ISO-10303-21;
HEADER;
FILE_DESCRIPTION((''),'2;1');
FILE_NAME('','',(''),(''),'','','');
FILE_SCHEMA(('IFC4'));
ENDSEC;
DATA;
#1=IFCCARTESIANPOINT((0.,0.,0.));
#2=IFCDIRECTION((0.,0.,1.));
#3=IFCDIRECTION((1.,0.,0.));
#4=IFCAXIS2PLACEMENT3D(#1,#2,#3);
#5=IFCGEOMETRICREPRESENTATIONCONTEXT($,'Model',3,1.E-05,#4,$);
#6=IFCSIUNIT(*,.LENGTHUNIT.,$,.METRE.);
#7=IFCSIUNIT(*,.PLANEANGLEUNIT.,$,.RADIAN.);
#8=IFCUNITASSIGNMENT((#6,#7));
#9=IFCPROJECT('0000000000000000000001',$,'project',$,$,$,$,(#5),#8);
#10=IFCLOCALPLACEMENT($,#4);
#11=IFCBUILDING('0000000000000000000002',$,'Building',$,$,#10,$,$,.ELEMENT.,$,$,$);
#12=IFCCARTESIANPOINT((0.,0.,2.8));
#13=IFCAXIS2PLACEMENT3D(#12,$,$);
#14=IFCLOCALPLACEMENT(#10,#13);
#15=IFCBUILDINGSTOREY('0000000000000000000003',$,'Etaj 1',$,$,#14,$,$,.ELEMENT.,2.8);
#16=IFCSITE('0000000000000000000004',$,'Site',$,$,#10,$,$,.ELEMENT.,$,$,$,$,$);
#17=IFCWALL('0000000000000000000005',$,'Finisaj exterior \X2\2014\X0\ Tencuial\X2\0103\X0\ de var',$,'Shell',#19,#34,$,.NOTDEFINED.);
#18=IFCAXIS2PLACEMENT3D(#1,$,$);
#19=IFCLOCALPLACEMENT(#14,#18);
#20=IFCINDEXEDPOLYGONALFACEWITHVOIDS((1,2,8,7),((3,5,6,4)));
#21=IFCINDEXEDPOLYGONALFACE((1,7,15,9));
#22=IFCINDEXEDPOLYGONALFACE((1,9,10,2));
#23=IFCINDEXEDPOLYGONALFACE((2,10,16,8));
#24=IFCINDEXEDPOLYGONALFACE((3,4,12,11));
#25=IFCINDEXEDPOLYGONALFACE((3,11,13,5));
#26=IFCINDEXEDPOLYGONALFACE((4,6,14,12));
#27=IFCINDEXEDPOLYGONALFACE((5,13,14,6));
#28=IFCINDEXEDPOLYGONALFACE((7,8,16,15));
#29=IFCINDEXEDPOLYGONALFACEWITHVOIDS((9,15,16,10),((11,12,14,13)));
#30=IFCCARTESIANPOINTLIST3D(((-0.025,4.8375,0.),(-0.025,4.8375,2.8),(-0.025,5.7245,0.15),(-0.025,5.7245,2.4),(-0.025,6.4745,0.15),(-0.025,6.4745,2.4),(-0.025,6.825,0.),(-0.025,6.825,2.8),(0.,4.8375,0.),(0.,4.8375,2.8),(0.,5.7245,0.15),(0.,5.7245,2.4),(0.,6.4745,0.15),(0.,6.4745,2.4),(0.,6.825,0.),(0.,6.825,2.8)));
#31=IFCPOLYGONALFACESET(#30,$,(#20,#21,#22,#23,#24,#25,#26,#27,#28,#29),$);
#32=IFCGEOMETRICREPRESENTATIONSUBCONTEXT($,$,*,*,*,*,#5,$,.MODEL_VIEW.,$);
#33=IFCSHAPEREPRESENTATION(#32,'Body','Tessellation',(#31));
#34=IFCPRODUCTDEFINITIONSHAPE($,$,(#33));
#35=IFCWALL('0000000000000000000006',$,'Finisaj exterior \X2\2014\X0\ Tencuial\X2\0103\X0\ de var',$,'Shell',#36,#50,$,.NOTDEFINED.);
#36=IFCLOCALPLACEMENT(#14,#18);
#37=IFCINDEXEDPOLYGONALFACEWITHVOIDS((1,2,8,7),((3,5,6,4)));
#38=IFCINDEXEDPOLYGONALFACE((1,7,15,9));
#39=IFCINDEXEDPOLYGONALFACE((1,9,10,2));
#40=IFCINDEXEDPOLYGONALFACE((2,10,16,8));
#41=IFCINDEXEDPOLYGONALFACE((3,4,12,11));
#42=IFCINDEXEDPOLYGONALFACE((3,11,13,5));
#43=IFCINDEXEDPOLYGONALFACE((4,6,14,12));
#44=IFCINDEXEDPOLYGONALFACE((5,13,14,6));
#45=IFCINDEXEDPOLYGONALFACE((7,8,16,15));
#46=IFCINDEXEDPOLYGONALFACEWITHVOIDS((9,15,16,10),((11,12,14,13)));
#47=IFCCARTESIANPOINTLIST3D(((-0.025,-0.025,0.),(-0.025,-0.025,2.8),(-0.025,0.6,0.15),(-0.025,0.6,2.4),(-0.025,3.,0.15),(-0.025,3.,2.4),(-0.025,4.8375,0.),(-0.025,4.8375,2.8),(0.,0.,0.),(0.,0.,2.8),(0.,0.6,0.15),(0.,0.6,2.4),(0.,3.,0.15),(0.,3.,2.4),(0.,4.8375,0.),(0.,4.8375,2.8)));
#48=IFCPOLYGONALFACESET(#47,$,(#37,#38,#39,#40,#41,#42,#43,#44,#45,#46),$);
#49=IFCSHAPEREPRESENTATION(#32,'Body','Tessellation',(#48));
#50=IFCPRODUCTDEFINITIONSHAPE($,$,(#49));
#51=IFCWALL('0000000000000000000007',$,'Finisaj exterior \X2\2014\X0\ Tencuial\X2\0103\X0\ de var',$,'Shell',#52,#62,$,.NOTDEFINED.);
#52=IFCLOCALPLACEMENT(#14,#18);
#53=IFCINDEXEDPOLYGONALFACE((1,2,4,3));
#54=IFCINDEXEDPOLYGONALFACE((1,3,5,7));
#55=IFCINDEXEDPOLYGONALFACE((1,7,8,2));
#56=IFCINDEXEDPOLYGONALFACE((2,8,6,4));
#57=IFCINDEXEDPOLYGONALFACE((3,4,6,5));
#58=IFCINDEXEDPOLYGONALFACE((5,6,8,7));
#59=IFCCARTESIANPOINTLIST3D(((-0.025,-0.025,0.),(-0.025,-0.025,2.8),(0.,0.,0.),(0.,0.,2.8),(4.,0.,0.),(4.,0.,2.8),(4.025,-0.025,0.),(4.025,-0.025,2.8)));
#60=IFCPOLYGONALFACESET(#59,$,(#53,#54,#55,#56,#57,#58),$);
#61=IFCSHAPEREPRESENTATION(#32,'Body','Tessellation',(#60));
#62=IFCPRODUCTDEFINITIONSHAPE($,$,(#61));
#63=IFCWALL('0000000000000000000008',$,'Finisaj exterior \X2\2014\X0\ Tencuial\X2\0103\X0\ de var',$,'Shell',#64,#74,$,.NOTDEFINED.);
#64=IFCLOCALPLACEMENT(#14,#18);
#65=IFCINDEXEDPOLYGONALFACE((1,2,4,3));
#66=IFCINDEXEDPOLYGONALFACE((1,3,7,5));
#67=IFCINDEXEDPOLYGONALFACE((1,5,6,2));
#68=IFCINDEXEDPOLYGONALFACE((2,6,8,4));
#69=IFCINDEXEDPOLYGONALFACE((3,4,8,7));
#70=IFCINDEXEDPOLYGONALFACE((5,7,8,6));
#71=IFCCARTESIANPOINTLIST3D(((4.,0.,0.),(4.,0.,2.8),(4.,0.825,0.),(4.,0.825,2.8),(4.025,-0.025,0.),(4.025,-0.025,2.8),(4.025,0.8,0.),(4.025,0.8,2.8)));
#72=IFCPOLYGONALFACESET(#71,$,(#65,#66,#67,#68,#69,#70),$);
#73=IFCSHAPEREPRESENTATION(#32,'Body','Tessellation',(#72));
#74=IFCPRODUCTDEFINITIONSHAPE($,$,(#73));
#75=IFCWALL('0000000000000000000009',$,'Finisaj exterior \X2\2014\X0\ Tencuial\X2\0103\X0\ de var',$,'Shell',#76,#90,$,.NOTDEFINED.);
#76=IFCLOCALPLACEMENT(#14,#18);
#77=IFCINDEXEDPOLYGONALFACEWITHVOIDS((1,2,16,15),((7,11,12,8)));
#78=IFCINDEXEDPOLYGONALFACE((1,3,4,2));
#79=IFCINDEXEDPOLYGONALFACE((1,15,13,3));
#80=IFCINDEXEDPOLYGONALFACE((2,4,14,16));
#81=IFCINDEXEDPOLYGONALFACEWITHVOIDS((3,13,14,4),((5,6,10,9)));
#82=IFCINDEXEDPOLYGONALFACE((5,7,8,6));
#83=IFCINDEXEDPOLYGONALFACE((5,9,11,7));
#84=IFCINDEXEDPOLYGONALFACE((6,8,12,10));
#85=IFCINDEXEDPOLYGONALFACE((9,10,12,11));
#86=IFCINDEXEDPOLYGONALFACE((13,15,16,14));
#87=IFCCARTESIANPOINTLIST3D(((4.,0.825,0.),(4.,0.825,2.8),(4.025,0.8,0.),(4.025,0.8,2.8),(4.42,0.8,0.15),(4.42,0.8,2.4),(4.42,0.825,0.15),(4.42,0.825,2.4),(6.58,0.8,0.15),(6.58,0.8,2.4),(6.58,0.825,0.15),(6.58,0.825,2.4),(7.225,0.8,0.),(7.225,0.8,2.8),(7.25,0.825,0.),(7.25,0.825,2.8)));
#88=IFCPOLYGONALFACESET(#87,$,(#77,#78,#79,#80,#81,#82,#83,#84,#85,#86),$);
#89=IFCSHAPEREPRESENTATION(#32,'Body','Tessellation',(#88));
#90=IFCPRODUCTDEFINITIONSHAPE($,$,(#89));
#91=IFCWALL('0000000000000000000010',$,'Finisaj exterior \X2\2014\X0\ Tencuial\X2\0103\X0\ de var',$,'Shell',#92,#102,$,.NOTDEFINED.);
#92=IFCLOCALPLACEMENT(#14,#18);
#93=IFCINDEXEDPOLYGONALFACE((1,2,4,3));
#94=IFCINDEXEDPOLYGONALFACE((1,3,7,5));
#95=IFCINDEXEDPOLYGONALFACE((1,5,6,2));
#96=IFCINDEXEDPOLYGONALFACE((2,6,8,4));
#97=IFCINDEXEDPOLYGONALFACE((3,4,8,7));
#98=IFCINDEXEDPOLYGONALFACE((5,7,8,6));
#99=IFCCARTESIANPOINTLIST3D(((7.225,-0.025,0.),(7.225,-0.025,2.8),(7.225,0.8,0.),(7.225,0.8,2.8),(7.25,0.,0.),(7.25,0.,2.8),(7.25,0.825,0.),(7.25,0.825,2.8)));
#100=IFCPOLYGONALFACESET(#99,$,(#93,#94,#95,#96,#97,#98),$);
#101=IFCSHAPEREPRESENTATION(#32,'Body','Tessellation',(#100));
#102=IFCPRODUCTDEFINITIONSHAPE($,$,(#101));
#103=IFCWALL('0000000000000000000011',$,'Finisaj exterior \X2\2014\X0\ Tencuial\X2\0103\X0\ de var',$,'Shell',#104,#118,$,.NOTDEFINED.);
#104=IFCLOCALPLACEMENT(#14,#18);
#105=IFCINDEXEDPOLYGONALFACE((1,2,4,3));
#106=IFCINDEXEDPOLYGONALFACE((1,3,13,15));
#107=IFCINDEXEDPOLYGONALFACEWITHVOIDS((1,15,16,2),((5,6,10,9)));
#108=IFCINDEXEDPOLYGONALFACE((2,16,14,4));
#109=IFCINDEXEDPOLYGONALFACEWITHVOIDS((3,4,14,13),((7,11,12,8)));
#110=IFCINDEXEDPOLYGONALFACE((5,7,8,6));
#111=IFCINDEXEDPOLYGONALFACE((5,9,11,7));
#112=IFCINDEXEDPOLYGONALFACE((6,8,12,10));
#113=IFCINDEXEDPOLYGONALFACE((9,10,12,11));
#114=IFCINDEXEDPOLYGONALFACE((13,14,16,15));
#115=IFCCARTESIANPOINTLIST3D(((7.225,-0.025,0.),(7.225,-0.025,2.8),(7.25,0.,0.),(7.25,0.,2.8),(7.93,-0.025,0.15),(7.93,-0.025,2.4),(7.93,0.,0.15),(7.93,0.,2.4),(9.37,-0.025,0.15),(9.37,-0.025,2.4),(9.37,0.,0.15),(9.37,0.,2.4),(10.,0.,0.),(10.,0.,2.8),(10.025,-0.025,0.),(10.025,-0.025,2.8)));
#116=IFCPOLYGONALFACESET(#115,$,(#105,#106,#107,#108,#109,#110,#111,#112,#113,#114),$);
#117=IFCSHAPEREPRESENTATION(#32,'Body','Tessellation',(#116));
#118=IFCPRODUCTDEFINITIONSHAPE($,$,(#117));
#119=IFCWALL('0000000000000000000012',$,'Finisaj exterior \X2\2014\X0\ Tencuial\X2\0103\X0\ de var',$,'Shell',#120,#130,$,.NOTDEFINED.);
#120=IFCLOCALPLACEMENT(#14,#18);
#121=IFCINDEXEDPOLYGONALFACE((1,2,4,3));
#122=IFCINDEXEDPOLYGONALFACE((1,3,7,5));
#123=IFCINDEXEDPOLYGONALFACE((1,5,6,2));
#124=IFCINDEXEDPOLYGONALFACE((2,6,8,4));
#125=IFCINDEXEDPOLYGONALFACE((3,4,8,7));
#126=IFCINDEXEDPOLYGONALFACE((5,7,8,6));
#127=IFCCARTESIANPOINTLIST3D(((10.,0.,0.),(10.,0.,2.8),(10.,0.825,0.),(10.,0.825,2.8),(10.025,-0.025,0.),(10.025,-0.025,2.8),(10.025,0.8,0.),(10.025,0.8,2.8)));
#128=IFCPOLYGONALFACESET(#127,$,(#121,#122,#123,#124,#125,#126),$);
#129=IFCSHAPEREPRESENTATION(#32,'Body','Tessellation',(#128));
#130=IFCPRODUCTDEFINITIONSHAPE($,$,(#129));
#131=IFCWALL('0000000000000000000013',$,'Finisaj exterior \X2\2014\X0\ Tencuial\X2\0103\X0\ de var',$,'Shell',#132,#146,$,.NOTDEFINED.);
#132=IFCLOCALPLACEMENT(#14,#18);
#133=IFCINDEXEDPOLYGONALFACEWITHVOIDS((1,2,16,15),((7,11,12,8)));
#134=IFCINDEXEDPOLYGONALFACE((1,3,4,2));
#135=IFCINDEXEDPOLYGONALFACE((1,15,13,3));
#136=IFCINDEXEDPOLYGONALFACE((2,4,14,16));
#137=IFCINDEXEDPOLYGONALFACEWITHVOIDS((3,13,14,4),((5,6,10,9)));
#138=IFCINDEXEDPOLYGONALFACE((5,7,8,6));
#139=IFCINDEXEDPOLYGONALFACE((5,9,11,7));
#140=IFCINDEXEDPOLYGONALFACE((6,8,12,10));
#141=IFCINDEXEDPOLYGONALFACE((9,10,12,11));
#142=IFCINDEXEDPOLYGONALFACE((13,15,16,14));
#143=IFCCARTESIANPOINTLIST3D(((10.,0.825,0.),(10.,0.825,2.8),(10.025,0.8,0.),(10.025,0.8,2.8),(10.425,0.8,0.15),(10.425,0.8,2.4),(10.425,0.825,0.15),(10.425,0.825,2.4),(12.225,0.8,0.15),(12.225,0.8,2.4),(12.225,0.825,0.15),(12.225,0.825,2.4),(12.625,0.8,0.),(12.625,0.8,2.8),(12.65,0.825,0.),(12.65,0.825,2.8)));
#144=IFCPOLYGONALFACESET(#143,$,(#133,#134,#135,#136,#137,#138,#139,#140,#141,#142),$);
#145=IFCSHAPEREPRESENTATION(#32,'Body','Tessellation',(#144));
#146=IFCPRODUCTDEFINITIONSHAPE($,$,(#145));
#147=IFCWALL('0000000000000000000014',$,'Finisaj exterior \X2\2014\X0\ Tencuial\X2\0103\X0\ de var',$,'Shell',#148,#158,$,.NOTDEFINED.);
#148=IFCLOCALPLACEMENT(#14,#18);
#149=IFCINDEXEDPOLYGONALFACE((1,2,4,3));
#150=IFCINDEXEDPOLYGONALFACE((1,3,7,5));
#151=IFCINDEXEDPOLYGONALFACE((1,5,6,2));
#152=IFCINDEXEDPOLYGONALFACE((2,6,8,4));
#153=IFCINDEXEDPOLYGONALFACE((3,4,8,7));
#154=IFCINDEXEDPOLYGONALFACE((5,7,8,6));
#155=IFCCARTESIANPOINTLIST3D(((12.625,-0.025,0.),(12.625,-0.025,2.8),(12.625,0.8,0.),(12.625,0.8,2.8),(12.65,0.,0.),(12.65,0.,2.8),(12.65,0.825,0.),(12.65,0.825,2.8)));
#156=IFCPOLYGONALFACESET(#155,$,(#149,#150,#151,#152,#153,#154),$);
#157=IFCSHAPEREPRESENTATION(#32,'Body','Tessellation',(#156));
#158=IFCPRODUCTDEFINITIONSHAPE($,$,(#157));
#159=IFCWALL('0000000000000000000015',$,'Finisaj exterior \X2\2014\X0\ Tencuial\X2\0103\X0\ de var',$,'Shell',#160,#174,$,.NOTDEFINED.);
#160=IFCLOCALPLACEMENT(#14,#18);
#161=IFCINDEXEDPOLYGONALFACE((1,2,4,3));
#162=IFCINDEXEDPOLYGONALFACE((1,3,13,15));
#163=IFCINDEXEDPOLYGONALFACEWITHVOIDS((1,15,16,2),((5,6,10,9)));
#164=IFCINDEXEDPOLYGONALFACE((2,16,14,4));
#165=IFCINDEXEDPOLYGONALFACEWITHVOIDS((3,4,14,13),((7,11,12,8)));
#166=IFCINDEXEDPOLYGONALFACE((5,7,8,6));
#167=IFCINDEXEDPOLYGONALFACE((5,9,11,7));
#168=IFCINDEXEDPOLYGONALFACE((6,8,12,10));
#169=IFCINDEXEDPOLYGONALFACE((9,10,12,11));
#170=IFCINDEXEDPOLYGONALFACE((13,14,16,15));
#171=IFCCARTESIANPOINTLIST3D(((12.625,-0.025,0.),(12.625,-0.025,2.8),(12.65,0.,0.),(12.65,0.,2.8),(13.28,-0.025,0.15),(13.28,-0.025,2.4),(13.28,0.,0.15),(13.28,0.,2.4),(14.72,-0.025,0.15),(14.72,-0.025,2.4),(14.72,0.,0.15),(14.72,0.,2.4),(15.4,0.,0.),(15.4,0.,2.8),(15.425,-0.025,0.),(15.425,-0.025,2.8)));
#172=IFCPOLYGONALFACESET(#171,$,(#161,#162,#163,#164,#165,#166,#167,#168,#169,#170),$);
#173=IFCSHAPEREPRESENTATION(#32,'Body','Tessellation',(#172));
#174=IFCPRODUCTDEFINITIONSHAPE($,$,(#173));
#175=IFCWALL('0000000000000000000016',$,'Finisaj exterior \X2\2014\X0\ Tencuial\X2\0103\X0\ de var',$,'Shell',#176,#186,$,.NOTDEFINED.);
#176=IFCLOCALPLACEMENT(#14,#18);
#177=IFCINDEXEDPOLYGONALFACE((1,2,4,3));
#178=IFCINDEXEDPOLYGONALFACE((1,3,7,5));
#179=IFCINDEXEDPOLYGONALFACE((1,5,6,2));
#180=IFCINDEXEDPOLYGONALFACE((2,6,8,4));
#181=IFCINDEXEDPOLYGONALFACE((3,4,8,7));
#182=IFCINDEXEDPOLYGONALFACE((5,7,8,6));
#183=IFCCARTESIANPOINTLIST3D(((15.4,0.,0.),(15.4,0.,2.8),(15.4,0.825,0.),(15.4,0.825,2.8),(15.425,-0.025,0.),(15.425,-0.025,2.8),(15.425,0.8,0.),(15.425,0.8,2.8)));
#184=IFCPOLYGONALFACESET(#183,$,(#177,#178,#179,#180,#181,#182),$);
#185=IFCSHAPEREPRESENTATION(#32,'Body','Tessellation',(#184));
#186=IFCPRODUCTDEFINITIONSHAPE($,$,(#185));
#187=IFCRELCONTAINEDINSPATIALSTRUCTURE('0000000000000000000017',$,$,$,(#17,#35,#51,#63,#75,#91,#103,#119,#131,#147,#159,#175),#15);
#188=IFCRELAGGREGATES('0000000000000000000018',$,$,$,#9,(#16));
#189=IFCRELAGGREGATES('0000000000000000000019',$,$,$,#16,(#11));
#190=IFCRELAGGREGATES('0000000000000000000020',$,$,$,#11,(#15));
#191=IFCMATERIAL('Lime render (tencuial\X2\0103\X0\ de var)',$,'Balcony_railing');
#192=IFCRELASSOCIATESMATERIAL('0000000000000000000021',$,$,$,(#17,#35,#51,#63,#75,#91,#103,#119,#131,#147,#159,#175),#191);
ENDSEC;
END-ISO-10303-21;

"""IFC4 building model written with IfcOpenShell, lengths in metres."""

from ifc_helpers import new_model, si_unit, frame, origin, origin_with_axes, origin_2d, place, context, subcontext, project, spatial, polyline, rectangle, outline, extrude, material, element, save


model = new_model("IFC4")

# Units and contexts
model_context = context("Model", 3, precision=1e-05, world=origin_with_axes())
sub_context = subcontext(model_context, None, None, "MODEL_VIEW")
ifc_project = project(units=[si_unit("LENGTHUNIT", "METRE"), si_unit("PLANEANGLEUNIT", "RADIAN")], contexts=[model_context])

# Site, building, storey
placement = place(None, origin_with_axes())
site = spatial("IfcSite", under=ifc_project, at=placement, Name="Site", CompositionType="ELEMENT")
building = spatial("IfcBuilding", under=site, at=placement, Name="Building", CompositionType="ELEMENT")
storey_placement = place(placement, frame((0.0, 0.0, 2.8)))
storey = spatial("IfcBuildingStorey", under=building, at=storey_placement, Name="Etaj 1", CompositionType="ELEMENT", Elevation=2.8)

# Walls, openings
ifc_material = material(Name="Lime render (tencuială de var)", Category="Balcony_railing")
wall_1_placement = place(storey_placement, origin_with_axes())
wall_1 = element("IfcWall", 1, at=wall_1_placement, inside=storey, material=ifc_material, Name="Finisaj exterior — Tencuială de var", ObjectType="Shell", PredefinedType="NOTDEFINED", context=sub_context, shape_type="SweptSolid", body=[
    extrude(outline(polyline([(-0.025, 6.825), (-0.025, 4.8375), (0.0, 4.8375), (0.0, 6.825), (-0.025, 6.825)])), origin(), (0.0, 0.0, 1.0), 2.8),
])
opening_1_placement = place(wall_1_placement, frame((-0.075, 6.0995, 0.15), z_axis=(1.0, 0.0, 0.0), x_axis=(0.0, 1.0, 0.0)))
element("IfcOpeningElement", 2, at=opening_1_placement, cuts=wall_1, PredefinedType="OPENING", context=sub_context, shape_type="SweptSolid", body=[
    extrude(rectangle(XDim=0.75, YDim=2.25, at=origin_2d()), frame((0.0, 1.125, 0.0)), (0.0, 0.0, 1.0), 0.5),
])
wall_2_placement = place(storey_placement, origin_with_axes())
wall_2 = element("IfcWall", 3, at=wall_2_placement, inside=storey, material=ifc_material, Name="Finisaj exterior — Tencuială de var", ObjectType="Shell", PredefinedType="NOTDEFINED", context=sub_context, shape_type="SweptSolid", body=[
    extrude(outline(polyline([(-0.025, 4.8375), (-0.025, -0.025), (0.0, 0.0), (0.0, 4.8375), (-0.025, 4.8375)])), origin(), (0.0, 0.0, 1.0), 2.8),
])
opening_2_placement = place(wall_2_placement, frame((-0.075, 1.8, 0.15), z_axis=(1.0, 0.0, 0.0), x_axis=(0.0, 1.0, 0.0)))
element("IfcOpeningElement", 4, at=opening_2_placement, cuts=wall_2, PredefinedType="OPENING", context=sub_context, shape_type="SweptSolid", body=[
    extrude(rectangle(XDim=2.4, YDim=2.25, at=origin_2d()), frame((0.0, 1.125, 0.0)), (0.0, 0.0, 1.0), 0.5),
])

# Walls
wall_3_placement = place(storey_placement, origin_with_axes())
element("IfcWall", 5, at=wall_3_placement, inside=storey, material=ifc_material, Name="Finisaj exterior — Tencuială de var", ObjectType="Shell", PredefinedType="NOTDEFINED", context=sub_context, shape_type="SweptSolid", body=[
    extrude(outline(polyline([(-0.025, -0.025), (4.025, -0.025), (4.0, 0.0), (0.0, 0.0), (-0.025, -0.025)])), origin(), (0.0, 0.0, 1.0), 2.8),
])
wall_4_placement = place(storey_placement, origin_with_axes())
element("IfcWall", 6, at=wall_4_placement, inside=storey, material=ifc_material, Name="Finisaj exterior — Tencuială de var", ObjectType="Shell", PredefinedType="NOTDEFINED", context=sub_context, shape_type="SweptSolid", body=[
    extrude(outline(polyline([(4.025, -0.025), (4.025, 0.8), (4.0, 0.825), (4.0, 0.0), (4.025, -0.025)])), origin(), (0.0, 0.0, 1.0), 2.8),
])

# Wall, opening
wall_5_placement = place(storey_placement, origin_with_axes())
wall_5 = element("IfcWall", 7, at=wall_5_placement, inside=storey, material=ifc_material, Name="Finisaj exterior — Tencuială de var", ObjectType="Shell", PredefinedType="NOTDEFINED", context=sub_context, shape_type="SweptSolid", body=[
    extrude(outline(polyline([(4.025, 0.8), (7.225, 0.8), (7.25, 0.825), (4.0, 0.825), (4.025, 0.8)])), origin(), (0.0, 0.0, 1.0), 2.8),
])
opening_3_placement = place(wall_5_placement, frame((5.5, 1.25, 0.15), z_axis=(0.0, -1.0, 0.0), x_axis=(1.0, 0.0, 0.0)))
element("IfcOpeningElement", 8, at=opening_3_placement, cuts=wall_5, PredefinedType="OPENING", context=sub_context, shape_type="SweptSolid", body=[
    extrude(rectangle(XDim=2.16, YDim=2.25, at=origin_2d()), frame((0.0, 1.125, 0.0)), (0.0, 0.0, 1.0), 0.5),
])

# Wall
wall_6_placement = place(storey_placement, origin_with_axes())
element("IfcWall", 9, at=wall_6_placement, inside=storey, material=ifc_material, Name="Finisaj exterior — Tencuială de var", ObjectType="Shell", PredefinedType="NOTDEFINED", context=sub_context, shape_type="SweptSolid", body=[
    extrude(outline(polyline([(7.225, 0.8), (7.225, -0.025), (7.25, 0.0), (7.25, 0.825), (7.225, 0.8)])), origin(), (0.0, 0.0, 1.0), 2.8),
])

# Wall, opening
wall_7_placement = place(storey_placement, origin_with_axes())
wall_7 = element("IfcWall", 10, at=wall_7_placement, inside=storey, material=ifc_material, Name="Finisaj exterior — Tencuială de var", ObjectType="Shell", PredefinedType="NOTDEFINED", context=sub_context, shape_type="SweptSolid", body=[
    extrude(outline(polyline([(7.225, -0.025), (10.025, -0.025), (10.0, 0.0), (7.25, 0.0), (7.225, -0.025)])), origin(), (0.0, 0.0, 1.0), 2.8),
])
opening_4_placement = place(wall_7_placement, frame((8.65, 0.425, 0.15), z_axis=(0.0, -1.0, 0.0), x_axis=(1.0, 0.0, 0.0)))
element("IfcOpeningElement", 11, at=opening_4_placement, cuts=wall_7, PredefinedType="OPENING", context=sub_context, shape_type="SweptSolid", body=[
    extrude(rectangle(XDim=1.44, YDim=2.25, at=origin_2d()), frame((0.0, 1.125, 0.0)), (0.0, 0.0, 1.0), 0.5),
])

# Wall
wall_8_placement = place(storey_placement, origin_with_axes())
element("IfcWall", 12, at=wall_8_placement, inside=storey, material=ifc_material, Name="Finisaj exterior — Tencuială de var", ObjectType="Shell", PredefinedType="NOTDEFINED", context=sub_context, shape_type="SweptSolid", body=[
    extrude(outline(polyline([(10.025, -0.025), (10.025, 0.8), (10.0, 0.825), (10.0, 0.0), (10.025, -0.025)])), origin(), (0.0, 0.0, 1.0), 2.8),
])

# Wall, opening
wall_9_placement = place(storey_placement, origin_with_axes())
wall_9 = element("IfcWall", 13, at=wall_9_placement, inside=storey, material=ifc_material, Name="Finisaj exterior — Tencuială de var", ObjectType="Shell", PredefinedType="NOTDEFINED", context=sub_context, shape_type="SweptSolid", body=[
    extrude(outline(polyline([(10.025, 0.8), (12.625, 0.8), (12.65, 0.825), (10.0, 0.825), (10.025, 0.8)])), origin(), (0.0, 0.0, 1.0), 2.8),
])
opening_5_placement = place(wall_9_placement, frame((11.325, 1.25, 0.15), z_axis=(0.0, -1.0, 0.0), x_axis=(1.0, 0.0, 0.0)))
element("IfcOpeningElement", 14, at=opening_5_placement, cuts=wall_9, PredefinedType="OPENING", context=sub_context, shape_type="SweptSolid", body=[
    extrude(rectangle(XDim=1.8, YDim=2.25, at=origin_2d()), frame((0.0, 1.125, 0.0)), (0.0, 0.0, 1.0), 0.5),
])

# Wall
wall_10_placement = place(storey_placement, origin_with_axes())
element("IfcWall", 15, at=wall_10_placement, inside=storey, material=ifc_material, Name="Finisaj exterior — Tencuială de var", ObjectType="Shell", PredefinedType="NOTDEFINED", context=sub_context, shape_type="SweptSolid", body=[
    extrude(outline(polyline([(12.625, 0.8), (12.625, -0.025), (12.65, 0.0), (12.65, 0.825), (12.625, 0.8)])), origin(), (0.0, 0.0, 1.0), 2.8),
])

# Wall, opening
wall_11_placement = place(storey_placement, origin_with_axes())
wall_11 = element("IfcWall", 16, at=wall_11_placement, inside=storey, material=ifc_material, Name="Finisaj exterior — Tencuială de var", ObjectType="Shell", PredefinedType="NOTDEFINED", context=sub_context, shape_type="SweptSolid", body=[
    extrude(outline(polyline([(12.625, -0.025), (15.425, -0.025), (15.4, 0.0), (12.65, 0.0), (12.625, -0.025)])), origin(), (0.0, 0.0, 1.0), 2.8),
])
opening_6_placement = place(wall_11_placement, frame((14.0, 0.425, 0.15), z_axis=(0.0, -1.0, 0.0), x_axis=(1.0, 0.0, 0.0)))
element("IfcOpeningElement", 17, at=opening_6_placement, cuts=wall_11, PredefinedType="OPENING", context=sub_context, shape_type="SweptSolid", body=[
    extrude(rectangle(XDim=1.44, YDim=2.25, at=origin_2d()), frame((0.0, 1.125, 0.0)), (0.0, 0.0, 1.0), 0.5),
])

# Wall
wall_12_placement = place(storey_placement, origin_with_axes())
element("IfcWall", 18, at=wall_12_placement, inside=storey, material=ifc_material, Name="Finisaj exterior — Tencuială de var", ObjectType="Shell", PredefinedType="NOTDEFINED", context=sub_context, shape_type="SweptSolid", body=[
    extrude(outline(polyline([(15.425, -0.025), (15.425, 0.8), (15.4, 0.825), (15.4, 0.0), (15.425, -0.025)])), origin(), (0.0, 0.0, 1.0), 2.8),
])

save(model, "model.ifc")
